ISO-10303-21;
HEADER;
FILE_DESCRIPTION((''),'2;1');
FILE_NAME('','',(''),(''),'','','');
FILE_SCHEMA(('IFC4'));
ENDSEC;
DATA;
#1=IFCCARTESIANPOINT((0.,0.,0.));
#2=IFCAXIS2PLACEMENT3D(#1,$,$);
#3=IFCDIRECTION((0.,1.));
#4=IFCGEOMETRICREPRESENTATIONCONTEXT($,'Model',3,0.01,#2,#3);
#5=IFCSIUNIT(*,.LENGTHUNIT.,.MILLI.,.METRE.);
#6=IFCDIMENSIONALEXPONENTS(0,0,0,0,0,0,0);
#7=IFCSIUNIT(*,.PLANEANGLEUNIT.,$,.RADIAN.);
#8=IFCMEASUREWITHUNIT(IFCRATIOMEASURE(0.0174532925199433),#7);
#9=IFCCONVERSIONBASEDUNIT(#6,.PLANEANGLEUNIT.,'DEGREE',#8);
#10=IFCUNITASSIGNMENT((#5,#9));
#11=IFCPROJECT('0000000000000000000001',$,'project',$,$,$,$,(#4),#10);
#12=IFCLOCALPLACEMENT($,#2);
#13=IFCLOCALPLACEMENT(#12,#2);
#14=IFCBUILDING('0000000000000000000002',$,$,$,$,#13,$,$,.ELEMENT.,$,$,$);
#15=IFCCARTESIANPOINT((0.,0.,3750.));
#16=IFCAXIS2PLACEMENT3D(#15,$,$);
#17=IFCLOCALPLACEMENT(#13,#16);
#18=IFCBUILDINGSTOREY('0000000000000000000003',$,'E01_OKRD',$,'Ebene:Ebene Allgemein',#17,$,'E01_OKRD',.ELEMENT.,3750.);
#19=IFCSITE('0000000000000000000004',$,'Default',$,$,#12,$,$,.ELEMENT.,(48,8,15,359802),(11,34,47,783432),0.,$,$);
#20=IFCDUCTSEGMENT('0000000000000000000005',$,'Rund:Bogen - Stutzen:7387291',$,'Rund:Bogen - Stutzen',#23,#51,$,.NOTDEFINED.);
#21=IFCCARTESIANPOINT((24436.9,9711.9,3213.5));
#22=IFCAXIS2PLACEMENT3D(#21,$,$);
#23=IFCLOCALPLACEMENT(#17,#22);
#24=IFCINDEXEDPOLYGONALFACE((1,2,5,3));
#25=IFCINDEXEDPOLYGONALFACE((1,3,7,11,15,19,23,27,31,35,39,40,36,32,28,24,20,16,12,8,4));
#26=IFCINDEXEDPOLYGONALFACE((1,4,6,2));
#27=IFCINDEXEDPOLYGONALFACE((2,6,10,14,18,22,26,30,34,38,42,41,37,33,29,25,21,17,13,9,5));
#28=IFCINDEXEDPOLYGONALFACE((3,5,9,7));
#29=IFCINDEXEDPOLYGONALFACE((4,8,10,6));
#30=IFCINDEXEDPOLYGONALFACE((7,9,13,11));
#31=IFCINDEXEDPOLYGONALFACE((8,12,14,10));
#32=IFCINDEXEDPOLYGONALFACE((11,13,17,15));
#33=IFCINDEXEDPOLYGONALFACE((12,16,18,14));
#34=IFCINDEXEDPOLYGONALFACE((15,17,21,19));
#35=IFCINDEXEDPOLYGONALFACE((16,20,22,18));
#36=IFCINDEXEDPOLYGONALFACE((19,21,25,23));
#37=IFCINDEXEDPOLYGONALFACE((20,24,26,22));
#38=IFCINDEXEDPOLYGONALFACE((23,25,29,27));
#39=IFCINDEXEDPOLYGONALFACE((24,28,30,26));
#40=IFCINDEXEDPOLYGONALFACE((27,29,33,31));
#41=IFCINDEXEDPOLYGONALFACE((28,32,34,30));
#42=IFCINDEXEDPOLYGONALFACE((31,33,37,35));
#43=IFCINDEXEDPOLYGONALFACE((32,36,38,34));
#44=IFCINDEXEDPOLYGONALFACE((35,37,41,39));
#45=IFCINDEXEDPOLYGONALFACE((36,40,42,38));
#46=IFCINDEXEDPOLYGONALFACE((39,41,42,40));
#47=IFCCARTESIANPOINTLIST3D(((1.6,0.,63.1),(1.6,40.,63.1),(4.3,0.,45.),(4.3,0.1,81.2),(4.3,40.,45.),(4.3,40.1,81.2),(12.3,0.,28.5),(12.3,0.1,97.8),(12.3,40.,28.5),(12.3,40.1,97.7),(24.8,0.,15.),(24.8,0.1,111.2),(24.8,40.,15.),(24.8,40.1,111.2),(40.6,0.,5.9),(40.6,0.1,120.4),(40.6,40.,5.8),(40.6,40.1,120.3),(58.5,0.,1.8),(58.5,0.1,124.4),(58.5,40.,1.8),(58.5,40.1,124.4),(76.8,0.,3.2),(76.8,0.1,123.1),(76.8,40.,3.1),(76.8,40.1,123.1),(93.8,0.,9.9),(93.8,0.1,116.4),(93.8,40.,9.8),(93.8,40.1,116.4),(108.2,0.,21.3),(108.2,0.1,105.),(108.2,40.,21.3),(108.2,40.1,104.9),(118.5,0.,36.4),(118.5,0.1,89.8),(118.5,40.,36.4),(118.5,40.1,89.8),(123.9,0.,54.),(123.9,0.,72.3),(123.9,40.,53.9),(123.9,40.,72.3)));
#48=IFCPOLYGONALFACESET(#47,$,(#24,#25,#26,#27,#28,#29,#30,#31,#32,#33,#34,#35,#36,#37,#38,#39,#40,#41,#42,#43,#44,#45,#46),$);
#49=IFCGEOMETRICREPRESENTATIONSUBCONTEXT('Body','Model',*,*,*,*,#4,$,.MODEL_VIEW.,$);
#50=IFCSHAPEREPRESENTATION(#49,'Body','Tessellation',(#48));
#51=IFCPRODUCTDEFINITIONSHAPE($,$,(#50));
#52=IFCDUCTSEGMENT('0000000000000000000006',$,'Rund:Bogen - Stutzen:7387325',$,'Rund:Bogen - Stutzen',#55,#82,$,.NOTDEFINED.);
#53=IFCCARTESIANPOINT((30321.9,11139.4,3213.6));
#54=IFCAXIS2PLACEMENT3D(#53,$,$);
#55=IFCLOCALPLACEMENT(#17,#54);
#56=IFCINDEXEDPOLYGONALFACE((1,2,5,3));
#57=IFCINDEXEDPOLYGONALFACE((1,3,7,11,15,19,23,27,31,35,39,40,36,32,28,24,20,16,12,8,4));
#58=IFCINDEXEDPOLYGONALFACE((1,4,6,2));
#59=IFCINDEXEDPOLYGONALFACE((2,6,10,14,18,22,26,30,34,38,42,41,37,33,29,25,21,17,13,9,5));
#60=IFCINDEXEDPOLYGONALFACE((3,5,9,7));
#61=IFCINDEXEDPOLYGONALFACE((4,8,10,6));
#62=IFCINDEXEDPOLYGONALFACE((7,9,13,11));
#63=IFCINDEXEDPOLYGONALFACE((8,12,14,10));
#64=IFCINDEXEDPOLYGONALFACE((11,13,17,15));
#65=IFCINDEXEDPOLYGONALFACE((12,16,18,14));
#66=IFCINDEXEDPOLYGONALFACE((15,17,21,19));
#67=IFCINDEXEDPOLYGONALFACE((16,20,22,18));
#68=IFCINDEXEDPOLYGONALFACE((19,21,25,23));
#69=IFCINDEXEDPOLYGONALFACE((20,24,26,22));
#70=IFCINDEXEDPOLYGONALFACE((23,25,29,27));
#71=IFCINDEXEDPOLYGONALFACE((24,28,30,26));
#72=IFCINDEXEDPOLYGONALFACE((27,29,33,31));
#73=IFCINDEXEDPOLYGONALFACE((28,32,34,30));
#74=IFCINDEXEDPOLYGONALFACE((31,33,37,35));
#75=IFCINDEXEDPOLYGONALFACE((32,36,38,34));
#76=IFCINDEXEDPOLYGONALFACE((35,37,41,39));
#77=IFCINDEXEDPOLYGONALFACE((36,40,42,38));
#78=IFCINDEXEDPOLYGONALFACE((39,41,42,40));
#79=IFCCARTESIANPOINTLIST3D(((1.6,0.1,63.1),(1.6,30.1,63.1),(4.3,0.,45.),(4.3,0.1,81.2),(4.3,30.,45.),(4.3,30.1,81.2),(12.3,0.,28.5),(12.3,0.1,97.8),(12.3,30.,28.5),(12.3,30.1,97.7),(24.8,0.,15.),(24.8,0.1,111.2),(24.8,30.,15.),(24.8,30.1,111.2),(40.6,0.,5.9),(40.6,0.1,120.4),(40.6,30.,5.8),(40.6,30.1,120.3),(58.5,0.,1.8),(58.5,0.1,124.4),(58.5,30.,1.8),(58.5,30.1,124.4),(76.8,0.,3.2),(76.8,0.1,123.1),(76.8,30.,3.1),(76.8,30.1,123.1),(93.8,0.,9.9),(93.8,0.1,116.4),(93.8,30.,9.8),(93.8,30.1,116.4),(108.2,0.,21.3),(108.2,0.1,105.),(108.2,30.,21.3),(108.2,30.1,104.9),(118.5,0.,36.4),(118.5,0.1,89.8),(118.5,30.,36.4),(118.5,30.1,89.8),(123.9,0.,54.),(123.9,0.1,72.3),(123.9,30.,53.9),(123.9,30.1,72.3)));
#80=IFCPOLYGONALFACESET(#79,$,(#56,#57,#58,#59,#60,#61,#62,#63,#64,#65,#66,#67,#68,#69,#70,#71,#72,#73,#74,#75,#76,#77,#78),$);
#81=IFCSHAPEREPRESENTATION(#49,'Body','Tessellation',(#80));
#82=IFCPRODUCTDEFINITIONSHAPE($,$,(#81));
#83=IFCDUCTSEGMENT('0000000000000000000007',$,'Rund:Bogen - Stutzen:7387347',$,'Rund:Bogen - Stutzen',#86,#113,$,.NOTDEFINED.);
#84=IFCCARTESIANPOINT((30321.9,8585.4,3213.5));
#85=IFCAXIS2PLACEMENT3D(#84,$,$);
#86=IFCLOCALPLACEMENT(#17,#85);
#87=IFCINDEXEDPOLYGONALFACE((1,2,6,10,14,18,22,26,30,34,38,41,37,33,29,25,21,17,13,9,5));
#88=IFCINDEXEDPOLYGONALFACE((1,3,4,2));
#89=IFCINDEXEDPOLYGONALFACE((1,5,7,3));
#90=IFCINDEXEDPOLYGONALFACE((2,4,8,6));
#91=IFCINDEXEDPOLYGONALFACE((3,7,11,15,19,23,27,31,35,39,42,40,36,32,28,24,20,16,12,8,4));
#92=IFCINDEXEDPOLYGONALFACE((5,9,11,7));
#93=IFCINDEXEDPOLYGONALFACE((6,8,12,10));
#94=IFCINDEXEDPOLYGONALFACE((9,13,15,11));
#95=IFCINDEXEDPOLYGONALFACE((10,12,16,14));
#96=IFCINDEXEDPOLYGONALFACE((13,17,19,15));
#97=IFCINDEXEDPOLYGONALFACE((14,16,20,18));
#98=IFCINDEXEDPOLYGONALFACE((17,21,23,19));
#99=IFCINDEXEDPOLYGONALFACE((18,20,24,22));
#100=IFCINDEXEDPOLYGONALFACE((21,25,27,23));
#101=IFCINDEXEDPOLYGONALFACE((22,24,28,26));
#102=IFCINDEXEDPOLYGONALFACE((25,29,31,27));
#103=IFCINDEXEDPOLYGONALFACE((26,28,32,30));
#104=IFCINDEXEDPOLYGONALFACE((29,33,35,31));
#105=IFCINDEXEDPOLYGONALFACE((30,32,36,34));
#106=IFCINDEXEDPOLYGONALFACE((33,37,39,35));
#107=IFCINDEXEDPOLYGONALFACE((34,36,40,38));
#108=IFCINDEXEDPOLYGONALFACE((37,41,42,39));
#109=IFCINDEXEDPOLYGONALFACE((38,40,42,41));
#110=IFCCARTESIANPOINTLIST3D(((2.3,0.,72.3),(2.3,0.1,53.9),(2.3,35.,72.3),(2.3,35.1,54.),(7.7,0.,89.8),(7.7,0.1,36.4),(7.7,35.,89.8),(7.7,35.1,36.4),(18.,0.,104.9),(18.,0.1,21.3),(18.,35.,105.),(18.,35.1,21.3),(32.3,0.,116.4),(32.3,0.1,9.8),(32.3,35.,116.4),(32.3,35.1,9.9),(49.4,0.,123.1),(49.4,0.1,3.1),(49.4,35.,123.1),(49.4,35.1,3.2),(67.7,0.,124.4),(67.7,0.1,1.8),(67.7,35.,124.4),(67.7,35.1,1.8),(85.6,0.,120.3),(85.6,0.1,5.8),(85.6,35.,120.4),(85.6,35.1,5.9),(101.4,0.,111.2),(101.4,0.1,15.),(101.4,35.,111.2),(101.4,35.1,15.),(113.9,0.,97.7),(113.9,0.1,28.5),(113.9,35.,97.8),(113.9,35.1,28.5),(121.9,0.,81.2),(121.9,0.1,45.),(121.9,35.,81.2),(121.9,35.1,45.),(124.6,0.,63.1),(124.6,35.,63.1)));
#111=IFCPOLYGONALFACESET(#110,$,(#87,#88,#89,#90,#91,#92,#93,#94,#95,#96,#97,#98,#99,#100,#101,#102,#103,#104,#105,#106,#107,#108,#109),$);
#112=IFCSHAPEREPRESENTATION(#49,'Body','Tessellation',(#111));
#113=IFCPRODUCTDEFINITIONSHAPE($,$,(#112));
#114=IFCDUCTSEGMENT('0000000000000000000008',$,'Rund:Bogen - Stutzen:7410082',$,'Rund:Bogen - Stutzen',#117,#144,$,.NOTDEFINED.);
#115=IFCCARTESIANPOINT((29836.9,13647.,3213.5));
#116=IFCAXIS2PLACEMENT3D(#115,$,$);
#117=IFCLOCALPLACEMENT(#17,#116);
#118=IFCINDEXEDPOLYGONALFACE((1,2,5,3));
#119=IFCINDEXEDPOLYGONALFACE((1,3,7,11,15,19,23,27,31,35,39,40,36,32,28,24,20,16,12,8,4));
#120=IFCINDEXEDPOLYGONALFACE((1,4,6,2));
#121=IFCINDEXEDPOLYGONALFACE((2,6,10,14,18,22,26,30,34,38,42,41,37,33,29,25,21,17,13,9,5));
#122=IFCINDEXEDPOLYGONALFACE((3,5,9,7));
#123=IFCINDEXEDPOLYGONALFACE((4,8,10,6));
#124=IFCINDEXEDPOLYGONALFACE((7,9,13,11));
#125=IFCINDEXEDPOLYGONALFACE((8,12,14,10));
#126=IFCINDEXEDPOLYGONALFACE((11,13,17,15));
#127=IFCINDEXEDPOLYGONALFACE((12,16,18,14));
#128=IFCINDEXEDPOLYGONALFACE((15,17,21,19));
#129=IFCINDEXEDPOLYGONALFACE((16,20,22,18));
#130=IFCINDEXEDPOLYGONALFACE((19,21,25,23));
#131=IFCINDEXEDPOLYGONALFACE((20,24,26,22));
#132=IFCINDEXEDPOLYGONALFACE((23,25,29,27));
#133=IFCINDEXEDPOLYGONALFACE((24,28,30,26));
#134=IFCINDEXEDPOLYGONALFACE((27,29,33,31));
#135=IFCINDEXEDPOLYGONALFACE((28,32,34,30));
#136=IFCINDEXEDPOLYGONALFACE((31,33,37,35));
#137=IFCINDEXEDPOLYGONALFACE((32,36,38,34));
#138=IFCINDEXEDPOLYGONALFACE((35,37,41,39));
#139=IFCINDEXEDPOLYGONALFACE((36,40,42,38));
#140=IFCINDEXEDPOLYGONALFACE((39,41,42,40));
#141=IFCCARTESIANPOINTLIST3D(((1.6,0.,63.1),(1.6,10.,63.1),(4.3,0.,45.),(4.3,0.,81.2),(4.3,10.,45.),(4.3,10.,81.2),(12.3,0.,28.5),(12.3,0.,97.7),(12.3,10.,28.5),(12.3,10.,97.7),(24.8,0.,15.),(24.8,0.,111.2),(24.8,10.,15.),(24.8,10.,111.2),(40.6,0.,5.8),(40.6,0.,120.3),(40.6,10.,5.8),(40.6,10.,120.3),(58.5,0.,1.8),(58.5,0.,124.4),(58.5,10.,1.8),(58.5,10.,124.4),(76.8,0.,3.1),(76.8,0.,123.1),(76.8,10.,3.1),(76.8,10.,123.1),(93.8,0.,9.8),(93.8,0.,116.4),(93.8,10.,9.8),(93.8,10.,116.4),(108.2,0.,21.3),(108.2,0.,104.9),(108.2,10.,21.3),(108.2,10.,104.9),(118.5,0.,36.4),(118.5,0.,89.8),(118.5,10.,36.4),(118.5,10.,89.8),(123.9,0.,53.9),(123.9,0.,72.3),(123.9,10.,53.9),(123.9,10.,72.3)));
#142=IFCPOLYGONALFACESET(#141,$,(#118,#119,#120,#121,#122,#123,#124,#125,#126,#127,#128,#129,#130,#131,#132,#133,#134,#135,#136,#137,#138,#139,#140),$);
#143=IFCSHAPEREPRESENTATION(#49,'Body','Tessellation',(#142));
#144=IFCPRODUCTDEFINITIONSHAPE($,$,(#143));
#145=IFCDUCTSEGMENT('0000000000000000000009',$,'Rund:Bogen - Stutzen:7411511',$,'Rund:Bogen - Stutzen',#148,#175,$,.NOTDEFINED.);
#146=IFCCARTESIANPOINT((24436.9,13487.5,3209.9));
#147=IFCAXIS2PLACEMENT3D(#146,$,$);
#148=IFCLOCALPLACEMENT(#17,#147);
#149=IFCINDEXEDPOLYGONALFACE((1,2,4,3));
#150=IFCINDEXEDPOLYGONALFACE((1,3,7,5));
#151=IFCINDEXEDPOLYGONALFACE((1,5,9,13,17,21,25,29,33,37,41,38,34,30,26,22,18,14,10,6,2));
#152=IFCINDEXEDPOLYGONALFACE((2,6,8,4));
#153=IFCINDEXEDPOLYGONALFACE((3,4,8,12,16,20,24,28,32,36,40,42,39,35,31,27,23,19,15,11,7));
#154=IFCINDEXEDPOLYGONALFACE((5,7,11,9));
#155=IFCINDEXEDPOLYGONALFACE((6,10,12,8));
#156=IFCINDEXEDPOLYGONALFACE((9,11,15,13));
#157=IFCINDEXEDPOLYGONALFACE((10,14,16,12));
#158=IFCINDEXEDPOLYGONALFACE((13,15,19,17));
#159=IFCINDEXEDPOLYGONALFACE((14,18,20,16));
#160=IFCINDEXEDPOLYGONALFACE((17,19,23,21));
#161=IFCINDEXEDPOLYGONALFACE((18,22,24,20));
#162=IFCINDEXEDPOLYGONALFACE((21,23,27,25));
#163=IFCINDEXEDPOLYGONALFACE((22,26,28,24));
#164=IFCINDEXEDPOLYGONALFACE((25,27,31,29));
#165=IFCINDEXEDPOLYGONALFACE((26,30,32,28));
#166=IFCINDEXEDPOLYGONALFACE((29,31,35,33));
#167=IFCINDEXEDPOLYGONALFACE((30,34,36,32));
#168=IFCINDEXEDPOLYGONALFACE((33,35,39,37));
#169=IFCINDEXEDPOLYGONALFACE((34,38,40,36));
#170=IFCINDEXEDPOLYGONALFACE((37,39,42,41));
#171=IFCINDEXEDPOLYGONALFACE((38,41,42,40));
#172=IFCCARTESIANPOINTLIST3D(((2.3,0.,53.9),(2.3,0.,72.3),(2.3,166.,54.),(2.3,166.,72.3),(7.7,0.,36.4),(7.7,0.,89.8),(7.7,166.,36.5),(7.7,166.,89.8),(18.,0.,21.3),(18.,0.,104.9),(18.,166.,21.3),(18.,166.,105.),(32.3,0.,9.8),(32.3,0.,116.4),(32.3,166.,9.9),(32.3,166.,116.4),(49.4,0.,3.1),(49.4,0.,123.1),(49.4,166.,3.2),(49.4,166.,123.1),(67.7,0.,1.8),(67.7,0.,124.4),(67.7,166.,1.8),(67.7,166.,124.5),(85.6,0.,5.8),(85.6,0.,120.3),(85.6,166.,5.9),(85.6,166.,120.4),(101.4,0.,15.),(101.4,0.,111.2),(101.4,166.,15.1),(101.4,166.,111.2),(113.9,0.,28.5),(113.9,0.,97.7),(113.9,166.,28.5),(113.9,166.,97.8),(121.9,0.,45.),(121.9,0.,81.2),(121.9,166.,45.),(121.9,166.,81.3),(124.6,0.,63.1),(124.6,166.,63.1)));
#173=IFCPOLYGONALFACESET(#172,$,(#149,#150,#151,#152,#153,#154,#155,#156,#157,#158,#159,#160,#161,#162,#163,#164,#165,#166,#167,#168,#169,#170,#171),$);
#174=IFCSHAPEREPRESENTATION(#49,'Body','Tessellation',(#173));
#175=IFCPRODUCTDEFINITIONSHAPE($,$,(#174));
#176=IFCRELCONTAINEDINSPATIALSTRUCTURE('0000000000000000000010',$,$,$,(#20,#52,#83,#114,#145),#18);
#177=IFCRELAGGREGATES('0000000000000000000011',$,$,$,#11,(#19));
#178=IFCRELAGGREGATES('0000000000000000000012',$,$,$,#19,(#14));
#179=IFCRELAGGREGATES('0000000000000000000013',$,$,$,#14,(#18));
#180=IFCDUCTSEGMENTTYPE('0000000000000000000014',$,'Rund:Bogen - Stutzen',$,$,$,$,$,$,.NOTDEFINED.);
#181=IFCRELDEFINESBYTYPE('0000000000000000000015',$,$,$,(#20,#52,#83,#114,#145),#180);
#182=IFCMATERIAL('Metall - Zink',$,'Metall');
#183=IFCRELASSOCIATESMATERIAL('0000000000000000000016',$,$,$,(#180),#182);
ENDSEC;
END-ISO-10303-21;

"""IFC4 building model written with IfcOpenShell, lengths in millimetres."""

from ifc_helpers import new_model, entity, si_unit, converted_unit, direction, frame, frame_2d, origin, place, context, subcontext, project, spatial, circle, extrude, material, type_object, element, save


model = new_model("IFC4")

# Units and contexts
model_context = context("Model", 3, precision=0.01, world=origin(), true_north=direction((0.0, 1.0)))
body_context = subcontext(model_context, "Body", "Model", "MODEL_VIEW")
ifc_project = project(units=[si_unit("LENGTHUNIT", "METRE", prefix="MILLI"), converted_unit("PLANEANGLEUNIT", "DEGREE", entity("IfcRatioMeasure", 0.0174532925199433), si_unit("PLANEANGLEUNIT", "RADIAN"), dimensions=[0, 0, 0, 0, 0, 0, 0])], contexts=[model_context])

# Site, building, storey
site_placement = place(None, origin())
site = spatial("IfcSite", under=ifc_project, at=site_placement, Name="Default", CompositionType="ELEMENT", RefLatitude=(48, 8, 15, 359802), RefLongitude=(11, 34, 47, 783432), RefElevation=0.0)
building_placement = place(site_placement, origin())
building = spatial("IfcBuilding", under=site, at=building_placement, CompositionType="ELEMENT")
storey_placement = place(building_placement, frame((0.0, 0.0, 3750.0)))
storey = spatial("IfcBuildingStorey", under=building, at=storey_placement, Name="E01_OKRD", ObjectType="Ebene:Ebene Allgemein", LongName="E01_OKRD", CompositionType="ELEMENT", Elevation=3750.0)

# Shared definitions
ifc_material_1 = material(Name="Metall - Zink", Category="Metall")

# Duct segments
duct_segment_type_1 = type_object("IfcDuctSegmentType", Name="Rund:Bogen - Stutzen", PredefinedType="NOTDEFINED", material=ifc_material_1)
duct_segment_1_placement = place(storey_placement, frame((24436.9, 9711.9, 3213.5)))
element("IfcDuctSegment", 1, at=duct_segment_1_placement, inside=storey, type_object=duct_segment_type_1, Name="Rund:Bogen - Stutzen:7387291", ObjectType="Rund:Bogen - Stutzen", PredefinedType="NOTDEFINED", context=body_context, shape_type="SweptSolid", body=[
    extrude(circle(Radius=61.5, at=frame_2d((0.0, 0.0), x_axis=(1.0, 0.0))), frame((63.1, 0.0, 63.1), z_axis=(0.0, 1.0, -0.000644), x_axis=(-1.0, 0.0, 0.0)), (0.0, 0.0, 1.0), 40.0),
])
duct_segment_2_placement = place(storey_placement, frame((30321.9, 11139.4, 3213.6)))
element("IfcDuctSegment", 2, at=duct_segment_2_placement, inside=storey, type_object=duct_segment_type_1, Name="Rund:Bogen - Stutzen:7387325", ObjectType="Rund:Bogen - Stutzen", PredefinedType="NOTDEFINED", context=body_context, shape_type="SweptSolid", body=[
    extrude(circle(Radius=61.5, at=frame_2d((0.0, 0.0), x_axis=(1.0, 0.0))), frame((63.1, 30.1, 63.1), z_axis=(0.0, -1.0, 0.000858), x_axis=(-1.0, 0.0, 0.0)), (0.0, 0.0, 1.0), 30.0),
])
duct_segment_3_placement = place(storey_placement, frame((30321.9, 8585.4, 3213.5)))
element("IfcDuctSegment", 3, at=duct_segment_3_placement, inside=storey, type_object=duct_segment_type_1, Name="Rund:Bogen - Stutzen:7387347", ObjectType="Rund:Bogen - Stutzen", PredefinedType="NOTDEFINED", context=body_context, shape_type="SweptSolid", body=[
    extrude(circle(Radius=61.5, at=frame_2d((0.0, 0.0), x_axis=(1.0, 0.0))), frame((63.1, 0.0, 63.1), z_axis=(0.0, 1.0, 0.000736), x_axis=(1.0, 0.0, 0.0)), (0.0, 0.0, 1.0), 35.0),
])
duct_segment_4_placement = place(storey_placement, frame((29836.9, 13647.0, 3213.5)))
element("IfcDuctSegment", 4, at=duct_segment_4_placement, inside=storey, type_object=duct_segment_type_1, Name="Rund:Bogen - Stutzen:7410082", ObjectType="Rund:Bogen - Stutzen", PredefinedType="NOTDEFINED", context=body_context, shape_type="SweptSolid", body=[
    extrude(circle(Radius=61.5, at=frame_2d((0.0, 0.0), x_axis=(1.0, 0.0))), frame((63.1, 0.0, 63.1), z_axis=(0.0, 1.0, 0.0), x_axis=(-1.0, 0.0, 0.0)), (0.0, 0.0, 1.0), 10.0),
])
duct_segment_5_placement = place(storey_placement, frame((24436.9, 13487.5, 3209.9)))
element("IfcDuctSegment", 5, at=duct_segment_5_placement, inside=storey, type_object=duct_segment_type_1, Name="Rund:Bogen - Stutzen:7411511", ObjectType="Rund:Bogen - Stutzen", PredefinedType="NOTDEFINED", context=body_context, shape_type="SweptSolid", body=[
    extrude(circle(Radius=61.5, at=frame_2d((0.0, 0.0), x_axis=(1.0, 0.0))), frame((63.1, 0.0, 63.1), z_axis=(0.0, 1.0, 0.000233), x_axis=(1.0, 0.0, 0.0)), (0.0, 0.0, 1.0), 166.0),
])

save(model, "model.ifc")
